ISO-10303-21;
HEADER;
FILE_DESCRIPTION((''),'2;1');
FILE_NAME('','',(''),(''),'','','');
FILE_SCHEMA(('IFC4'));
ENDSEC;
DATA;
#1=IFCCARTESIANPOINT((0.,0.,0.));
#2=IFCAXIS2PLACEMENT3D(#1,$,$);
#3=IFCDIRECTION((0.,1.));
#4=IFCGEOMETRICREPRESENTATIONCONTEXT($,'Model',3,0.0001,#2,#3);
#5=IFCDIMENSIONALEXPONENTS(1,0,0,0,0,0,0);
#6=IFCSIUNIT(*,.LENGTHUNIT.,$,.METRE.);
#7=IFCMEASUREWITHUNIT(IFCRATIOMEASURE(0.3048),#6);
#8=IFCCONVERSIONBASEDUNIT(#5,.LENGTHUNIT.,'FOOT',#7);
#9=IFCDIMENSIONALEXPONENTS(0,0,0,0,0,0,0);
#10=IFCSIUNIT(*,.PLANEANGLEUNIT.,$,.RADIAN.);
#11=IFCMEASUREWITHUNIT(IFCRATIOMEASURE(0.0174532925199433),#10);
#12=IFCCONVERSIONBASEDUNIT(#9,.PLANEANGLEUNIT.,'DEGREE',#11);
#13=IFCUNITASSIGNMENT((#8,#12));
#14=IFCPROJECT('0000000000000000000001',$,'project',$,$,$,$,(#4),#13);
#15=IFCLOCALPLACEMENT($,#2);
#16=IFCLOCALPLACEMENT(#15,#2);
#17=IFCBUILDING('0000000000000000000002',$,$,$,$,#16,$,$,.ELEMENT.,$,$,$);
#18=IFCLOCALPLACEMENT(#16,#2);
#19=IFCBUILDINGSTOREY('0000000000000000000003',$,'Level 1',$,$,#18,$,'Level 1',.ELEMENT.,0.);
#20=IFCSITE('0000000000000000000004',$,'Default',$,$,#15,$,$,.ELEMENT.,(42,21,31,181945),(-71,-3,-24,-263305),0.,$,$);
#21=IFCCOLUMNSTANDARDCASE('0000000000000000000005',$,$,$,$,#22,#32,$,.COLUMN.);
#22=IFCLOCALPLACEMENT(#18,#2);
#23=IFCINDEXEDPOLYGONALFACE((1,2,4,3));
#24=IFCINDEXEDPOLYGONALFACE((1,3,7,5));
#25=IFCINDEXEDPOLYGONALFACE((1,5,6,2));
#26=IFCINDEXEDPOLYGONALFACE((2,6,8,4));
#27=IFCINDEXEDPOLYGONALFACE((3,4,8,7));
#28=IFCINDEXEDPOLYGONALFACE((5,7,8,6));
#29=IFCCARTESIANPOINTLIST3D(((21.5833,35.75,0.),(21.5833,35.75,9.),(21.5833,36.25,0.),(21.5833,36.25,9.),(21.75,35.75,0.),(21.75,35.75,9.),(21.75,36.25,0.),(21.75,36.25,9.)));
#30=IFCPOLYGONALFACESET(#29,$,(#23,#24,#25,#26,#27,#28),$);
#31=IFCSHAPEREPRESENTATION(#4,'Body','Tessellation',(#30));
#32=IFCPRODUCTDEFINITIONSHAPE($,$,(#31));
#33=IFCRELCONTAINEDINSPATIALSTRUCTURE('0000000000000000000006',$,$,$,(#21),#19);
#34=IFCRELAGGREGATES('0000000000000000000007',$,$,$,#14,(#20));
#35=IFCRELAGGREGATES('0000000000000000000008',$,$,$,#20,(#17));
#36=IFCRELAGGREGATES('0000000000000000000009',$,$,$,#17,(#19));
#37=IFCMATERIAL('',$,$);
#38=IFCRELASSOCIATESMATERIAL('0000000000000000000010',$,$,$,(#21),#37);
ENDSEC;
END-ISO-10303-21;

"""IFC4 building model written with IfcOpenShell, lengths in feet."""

from ifc_helpers import new_model, entity, si_unit, converted_unit, direction, frame, origin, place, context, project, spatial, rectangle, extrude, material, element, save


model = new_model("IFC4")

# Units and contexts
model_context = context("Model", 3, precision=0.0001, world=origin(), true_north=direction((0.0, 1.0)))
ifc_project = project(units=[converted_unit("LENGTHUNIT", "FOOT", entity("IfcRatioMeasure", 0.3048), si_unit("LENGTHUNIT", "METRE"), dimensions=[1, 0, 0, 0, 0, 0, 0]), converted_unit("PLANEANGLEUNIT", "DEGREE", entity("IfcRatioMeasure", 0.0174532925199433), si_unit("PLANEANGLEUNIT", "RADIAN"), dimensions=[0, 0, 0, 0, 0, 0, 0])], contexts=[model_context])

# Site, building, storey
site_placement = place(None, origin())
site = spatial("IfcSite", under=ifc_project, at=site_placement, Name="Default", CompositionType="ELEMENT", RefLatitude=(42, 21, 31, 181945), RefLongitude=(-71, -3, -24, -263305), RefElevation=0.0)
building_placement = place(site_placement, origin())
building = spatial("IfcBuilding", under=site, at=building_placement, CompositionType="ELEMENT")
storey_placement = place(building_placement, origin())
storey = spatial("IfcBuildingStorey", under=building, at=storey_placement, Name="Level 1", LongName="Level 1", CompositionType="ELEMENT", Elevation=0.0)

# Column
ifc_material_1 = material(Name="")
placement_1 = place(storey_placement, frame((0.25, 36.0, 0.0)))
column_placement = place(placement_1, frame((21.4167, 0.0, 0.0), z_axis=(0.0, 0.0, 1.0), x_axis=(1.0, 0.0, 0.0)))
element("IfcColumnStandardCase", 1, at=column_placement, inside=storey, material=ifc_material_1, PredefinedType="COLUMN", context=model_context, shape_type="SweptSolid", body=[
    extrude(rectangle(XDim=0.1667, YDim=0.5), origin(), (0.0, 0.0, 1.0), 9.0),
])

save(model, "model.ifc")
